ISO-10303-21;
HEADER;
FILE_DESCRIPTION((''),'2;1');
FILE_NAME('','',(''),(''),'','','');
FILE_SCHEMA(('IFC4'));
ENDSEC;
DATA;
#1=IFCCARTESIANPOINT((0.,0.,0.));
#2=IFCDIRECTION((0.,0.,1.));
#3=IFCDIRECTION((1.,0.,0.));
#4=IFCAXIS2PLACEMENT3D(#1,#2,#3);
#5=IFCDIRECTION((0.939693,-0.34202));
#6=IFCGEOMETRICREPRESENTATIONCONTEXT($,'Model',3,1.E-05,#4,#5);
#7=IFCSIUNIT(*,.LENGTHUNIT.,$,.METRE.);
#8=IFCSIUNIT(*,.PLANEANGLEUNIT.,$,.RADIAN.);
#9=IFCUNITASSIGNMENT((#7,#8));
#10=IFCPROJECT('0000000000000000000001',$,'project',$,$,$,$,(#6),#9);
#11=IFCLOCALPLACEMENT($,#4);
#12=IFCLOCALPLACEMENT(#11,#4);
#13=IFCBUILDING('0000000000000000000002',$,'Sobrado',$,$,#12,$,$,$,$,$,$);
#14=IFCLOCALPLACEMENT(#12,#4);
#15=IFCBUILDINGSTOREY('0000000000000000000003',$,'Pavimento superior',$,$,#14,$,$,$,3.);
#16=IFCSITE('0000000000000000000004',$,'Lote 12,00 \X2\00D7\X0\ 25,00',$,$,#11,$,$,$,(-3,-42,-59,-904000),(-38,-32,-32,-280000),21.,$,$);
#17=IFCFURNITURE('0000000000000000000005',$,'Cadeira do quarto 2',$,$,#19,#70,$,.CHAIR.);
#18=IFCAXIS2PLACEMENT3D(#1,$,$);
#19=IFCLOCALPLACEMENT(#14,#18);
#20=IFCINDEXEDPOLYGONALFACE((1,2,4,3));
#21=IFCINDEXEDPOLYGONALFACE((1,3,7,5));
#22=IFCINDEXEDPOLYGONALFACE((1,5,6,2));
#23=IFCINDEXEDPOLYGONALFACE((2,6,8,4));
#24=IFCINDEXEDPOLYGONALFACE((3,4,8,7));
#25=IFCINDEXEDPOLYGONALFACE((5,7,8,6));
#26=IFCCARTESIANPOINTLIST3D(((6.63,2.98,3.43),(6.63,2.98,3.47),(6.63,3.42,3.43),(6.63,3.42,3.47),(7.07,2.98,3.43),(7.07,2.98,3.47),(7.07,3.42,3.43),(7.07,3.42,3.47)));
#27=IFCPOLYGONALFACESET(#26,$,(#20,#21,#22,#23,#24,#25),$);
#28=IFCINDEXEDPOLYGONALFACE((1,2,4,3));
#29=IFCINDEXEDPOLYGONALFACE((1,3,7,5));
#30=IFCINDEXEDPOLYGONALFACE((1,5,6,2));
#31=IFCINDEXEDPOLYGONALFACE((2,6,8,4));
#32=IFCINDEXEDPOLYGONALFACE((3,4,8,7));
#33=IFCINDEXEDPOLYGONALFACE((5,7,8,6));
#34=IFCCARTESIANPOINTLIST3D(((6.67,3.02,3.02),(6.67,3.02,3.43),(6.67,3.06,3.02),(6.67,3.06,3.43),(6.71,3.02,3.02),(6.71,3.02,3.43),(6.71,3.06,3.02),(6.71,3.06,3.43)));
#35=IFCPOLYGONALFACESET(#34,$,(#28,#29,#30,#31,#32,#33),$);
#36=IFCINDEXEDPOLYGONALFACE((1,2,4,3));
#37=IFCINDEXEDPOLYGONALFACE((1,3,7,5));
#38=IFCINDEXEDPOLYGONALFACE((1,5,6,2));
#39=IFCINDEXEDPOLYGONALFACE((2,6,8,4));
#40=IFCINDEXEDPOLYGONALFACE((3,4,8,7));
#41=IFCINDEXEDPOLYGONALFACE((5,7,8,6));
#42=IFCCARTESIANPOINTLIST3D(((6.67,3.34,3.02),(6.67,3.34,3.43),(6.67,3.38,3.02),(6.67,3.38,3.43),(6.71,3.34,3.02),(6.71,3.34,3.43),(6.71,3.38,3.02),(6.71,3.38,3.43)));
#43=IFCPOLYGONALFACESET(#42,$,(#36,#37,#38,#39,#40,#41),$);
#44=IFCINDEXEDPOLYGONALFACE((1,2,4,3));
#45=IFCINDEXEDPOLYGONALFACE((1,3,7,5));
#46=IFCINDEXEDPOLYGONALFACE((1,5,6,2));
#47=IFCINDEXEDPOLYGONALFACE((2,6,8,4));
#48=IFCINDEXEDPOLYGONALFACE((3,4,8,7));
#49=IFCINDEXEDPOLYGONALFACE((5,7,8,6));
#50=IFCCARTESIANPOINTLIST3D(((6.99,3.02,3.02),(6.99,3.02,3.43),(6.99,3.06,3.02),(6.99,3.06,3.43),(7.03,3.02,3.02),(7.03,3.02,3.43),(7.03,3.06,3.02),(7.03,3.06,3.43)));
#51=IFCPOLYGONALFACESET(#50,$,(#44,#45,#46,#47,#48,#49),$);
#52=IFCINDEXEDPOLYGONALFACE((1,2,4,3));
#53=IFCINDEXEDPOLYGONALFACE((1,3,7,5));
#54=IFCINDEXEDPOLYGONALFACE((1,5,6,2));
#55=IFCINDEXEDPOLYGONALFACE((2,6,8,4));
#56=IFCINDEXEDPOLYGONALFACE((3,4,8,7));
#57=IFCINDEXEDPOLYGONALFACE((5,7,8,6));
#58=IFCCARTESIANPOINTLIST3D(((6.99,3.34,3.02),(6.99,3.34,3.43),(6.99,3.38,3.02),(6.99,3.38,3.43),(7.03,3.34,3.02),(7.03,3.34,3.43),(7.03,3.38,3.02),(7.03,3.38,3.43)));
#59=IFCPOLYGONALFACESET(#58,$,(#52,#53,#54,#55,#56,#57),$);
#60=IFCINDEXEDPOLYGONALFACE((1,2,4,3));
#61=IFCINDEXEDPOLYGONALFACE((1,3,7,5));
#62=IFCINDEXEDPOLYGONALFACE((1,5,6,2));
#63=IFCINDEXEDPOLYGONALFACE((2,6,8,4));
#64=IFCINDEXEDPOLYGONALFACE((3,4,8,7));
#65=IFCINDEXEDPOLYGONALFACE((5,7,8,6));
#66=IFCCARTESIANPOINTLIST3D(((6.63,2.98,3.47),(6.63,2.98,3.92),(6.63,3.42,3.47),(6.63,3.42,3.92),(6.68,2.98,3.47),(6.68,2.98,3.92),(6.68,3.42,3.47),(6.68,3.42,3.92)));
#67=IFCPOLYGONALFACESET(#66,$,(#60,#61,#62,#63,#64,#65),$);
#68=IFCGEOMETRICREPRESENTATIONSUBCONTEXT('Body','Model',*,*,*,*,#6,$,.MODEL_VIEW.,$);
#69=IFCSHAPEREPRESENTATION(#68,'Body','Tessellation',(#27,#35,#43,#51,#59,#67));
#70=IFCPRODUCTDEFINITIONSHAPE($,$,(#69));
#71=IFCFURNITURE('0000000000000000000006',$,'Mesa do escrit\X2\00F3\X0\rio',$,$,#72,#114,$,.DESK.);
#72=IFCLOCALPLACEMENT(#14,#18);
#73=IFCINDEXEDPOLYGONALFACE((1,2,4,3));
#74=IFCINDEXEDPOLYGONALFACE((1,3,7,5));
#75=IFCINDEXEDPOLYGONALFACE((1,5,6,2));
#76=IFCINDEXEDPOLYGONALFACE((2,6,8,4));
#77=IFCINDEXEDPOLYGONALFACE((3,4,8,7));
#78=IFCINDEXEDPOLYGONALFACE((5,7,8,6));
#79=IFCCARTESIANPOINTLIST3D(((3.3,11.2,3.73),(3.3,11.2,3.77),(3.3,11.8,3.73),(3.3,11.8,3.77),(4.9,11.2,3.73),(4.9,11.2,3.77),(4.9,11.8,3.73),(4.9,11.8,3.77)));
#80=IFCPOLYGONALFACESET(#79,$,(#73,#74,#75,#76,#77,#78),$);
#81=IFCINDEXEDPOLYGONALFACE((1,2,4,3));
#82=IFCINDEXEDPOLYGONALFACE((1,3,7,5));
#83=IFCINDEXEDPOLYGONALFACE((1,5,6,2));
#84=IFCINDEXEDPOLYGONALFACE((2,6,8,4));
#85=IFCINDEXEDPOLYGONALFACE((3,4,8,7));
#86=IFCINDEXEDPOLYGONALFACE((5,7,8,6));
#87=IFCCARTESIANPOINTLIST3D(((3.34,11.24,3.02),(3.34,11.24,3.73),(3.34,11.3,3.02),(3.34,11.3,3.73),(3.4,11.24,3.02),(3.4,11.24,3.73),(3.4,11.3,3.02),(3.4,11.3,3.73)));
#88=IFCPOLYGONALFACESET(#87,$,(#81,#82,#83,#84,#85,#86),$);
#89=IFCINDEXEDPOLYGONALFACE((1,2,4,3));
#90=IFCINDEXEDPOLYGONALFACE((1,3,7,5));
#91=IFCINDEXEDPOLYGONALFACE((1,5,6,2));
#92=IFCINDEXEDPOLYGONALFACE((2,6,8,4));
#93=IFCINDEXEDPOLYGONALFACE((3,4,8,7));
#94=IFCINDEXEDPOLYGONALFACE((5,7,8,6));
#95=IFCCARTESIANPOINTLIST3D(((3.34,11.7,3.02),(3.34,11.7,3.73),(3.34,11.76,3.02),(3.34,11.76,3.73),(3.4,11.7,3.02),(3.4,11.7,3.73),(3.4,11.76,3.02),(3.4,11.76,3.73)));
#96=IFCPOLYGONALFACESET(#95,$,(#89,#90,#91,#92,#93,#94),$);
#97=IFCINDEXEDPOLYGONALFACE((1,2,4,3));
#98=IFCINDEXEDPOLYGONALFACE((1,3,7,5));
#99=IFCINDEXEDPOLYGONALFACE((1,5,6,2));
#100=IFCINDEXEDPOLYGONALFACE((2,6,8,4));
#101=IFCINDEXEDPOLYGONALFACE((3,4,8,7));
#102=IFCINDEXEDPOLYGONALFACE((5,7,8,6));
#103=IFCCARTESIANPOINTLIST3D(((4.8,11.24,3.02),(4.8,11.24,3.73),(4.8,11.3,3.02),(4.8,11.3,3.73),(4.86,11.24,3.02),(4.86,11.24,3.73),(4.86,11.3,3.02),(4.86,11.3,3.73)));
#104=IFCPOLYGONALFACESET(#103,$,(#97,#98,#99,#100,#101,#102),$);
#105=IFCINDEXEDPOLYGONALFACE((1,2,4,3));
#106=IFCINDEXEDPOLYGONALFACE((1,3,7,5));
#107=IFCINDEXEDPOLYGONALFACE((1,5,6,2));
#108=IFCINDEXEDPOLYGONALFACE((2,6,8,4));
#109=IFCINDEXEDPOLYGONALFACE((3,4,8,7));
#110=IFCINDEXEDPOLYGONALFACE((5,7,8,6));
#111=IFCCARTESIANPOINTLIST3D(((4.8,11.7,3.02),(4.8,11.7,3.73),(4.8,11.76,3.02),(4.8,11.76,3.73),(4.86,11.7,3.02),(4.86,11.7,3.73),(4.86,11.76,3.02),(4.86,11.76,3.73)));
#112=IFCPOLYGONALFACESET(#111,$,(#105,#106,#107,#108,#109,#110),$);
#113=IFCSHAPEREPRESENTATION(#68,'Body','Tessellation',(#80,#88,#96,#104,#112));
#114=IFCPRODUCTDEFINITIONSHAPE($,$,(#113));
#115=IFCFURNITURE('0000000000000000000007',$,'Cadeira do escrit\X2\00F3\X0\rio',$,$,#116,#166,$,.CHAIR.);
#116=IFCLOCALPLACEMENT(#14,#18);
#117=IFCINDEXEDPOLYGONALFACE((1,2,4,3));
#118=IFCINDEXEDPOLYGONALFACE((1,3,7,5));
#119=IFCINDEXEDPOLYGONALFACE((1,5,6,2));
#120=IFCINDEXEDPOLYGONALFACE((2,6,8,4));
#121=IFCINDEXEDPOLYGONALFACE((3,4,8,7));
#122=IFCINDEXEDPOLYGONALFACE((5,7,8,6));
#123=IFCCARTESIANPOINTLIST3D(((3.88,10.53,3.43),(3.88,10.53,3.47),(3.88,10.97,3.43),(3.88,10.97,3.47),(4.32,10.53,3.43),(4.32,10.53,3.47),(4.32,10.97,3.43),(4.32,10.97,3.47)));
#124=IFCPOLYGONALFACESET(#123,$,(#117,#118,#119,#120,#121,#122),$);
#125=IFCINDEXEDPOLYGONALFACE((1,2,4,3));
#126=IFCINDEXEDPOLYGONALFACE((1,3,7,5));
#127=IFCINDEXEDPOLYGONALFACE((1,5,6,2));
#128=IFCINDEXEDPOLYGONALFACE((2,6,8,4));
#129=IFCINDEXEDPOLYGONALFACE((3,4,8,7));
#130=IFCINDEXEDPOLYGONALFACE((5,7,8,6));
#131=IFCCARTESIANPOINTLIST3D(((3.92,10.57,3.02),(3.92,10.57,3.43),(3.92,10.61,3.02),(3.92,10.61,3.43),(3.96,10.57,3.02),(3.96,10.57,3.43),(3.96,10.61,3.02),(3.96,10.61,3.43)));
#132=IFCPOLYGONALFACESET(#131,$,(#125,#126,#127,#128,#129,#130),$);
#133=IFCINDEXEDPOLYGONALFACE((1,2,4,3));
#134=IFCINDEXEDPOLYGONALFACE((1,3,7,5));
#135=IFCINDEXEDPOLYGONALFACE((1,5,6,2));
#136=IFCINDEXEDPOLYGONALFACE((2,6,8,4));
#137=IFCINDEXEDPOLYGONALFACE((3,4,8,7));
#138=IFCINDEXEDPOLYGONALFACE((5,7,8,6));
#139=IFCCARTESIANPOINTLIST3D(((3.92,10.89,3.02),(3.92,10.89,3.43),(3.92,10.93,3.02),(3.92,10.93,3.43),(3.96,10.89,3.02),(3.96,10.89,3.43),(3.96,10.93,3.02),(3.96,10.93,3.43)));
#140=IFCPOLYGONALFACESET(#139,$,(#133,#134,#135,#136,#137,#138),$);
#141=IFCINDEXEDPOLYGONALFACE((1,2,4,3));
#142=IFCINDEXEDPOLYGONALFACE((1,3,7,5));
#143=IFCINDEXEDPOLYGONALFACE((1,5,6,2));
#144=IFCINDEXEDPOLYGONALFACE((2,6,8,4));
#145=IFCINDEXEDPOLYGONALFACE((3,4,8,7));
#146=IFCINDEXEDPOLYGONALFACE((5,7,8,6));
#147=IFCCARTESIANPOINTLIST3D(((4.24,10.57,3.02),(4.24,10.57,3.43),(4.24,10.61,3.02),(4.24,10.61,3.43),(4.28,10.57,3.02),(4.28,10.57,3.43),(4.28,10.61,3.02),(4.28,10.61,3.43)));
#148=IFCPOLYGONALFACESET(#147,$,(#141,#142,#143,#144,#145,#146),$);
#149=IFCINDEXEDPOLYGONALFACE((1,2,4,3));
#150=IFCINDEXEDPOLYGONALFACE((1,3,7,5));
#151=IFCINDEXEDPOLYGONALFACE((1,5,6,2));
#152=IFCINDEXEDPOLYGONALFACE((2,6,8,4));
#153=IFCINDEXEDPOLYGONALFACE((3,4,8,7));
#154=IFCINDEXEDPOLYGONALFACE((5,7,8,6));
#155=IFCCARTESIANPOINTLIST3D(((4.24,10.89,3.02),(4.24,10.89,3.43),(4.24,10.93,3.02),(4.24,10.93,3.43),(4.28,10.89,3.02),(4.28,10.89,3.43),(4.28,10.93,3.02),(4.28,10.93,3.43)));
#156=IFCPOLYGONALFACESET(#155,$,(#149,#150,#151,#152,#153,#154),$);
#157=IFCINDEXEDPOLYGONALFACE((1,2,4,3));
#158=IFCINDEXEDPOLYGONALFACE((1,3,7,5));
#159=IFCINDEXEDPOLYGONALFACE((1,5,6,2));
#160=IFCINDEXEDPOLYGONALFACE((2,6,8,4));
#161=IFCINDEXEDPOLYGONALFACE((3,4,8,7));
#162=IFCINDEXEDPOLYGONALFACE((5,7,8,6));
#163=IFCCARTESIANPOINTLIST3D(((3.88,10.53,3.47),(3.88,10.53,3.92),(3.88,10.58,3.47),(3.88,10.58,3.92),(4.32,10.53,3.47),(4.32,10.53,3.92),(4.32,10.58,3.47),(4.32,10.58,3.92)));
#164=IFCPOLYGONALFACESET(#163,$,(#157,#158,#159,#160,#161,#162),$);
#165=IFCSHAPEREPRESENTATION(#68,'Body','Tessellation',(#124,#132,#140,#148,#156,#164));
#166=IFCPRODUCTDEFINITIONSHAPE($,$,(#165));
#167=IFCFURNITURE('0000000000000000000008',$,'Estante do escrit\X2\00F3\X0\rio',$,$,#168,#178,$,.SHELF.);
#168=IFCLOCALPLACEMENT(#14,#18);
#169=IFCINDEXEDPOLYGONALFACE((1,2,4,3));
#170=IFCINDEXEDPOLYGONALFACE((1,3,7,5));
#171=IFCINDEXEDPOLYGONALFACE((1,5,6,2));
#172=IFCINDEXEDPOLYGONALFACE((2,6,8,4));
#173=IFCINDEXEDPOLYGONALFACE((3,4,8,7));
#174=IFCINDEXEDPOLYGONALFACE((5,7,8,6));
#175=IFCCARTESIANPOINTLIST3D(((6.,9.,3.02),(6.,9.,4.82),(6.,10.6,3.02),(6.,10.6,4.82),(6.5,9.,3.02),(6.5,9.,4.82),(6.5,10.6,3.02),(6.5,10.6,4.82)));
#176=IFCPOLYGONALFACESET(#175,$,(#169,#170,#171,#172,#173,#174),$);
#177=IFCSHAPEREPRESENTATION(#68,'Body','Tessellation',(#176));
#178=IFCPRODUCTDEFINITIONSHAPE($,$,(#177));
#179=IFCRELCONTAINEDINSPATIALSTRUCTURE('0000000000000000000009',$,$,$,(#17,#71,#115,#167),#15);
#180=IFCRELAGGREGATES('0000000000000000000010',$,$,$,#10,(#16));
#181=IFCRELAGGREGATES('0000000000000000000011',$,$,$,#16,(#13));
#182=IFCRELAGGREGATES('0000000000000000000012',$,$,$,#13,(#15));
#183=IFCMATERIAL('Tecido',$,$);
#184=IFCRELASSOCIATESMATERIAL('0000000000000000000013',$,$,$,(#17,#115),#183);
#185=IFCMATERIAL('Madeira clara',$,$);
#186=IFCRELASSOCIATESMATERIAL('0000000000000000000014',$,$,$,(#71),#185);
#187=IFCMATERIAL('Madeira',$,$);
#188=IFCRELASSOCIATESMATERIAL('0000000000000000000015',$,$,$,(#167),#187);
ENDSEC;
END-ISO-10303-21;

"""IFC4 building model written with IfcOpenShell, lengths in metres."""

from ifc_helpers import new_model, si_unit, direction, frame, origin_with_axes, place, context, subcontext, project, spatial, line, indexed_curve, outline, extrude, material, element, save


model = new_model("IFC4")

# Units and contexts
model_context = context("Model", 3, precision=1e-05, world=origin_with_axes(), true_north=direction((0.939693, -0.34202)))
body_context = subcontext(model_context, "Body", "Model", "MODEL_VIEW")
ifc_project = project(units=[si_unit("LENGTHUNIT", "METRE"), si_unit("PLANEANGLEUNIT", "RADIAN")], contexts=[model_context])

# Site, building, storey
site_placement = place(None, origin_with_axes())
site = spatial("IfcSite", under=ifc_project, at=site_placement, Name="Lote 12,00 × 25,00", RefLatitude=(-3, -42, -59, -904000), RefLongitude=(-38, -32, -32, -280000), RefElevation=21.0)
building_placement = place(site_placement, origin_with_axes())
building = spatial("IfcBuilding", under=site, at=building_placement, Name="Sobrado")
storey_placement = place(building_placement, origin_with_axes())
storey = spatial("IfcBuildingStorey", under=building, at=storey_placement, Name="Pavimento superior", Elevation=3.0)

# Furniture
ifc_material_1 = material(Name="Tecido")
ifc_material_2 = material(Name="Madeira")
ifc_material_3 = material(Name="Madeira clara")
furniture_1_placement = place(storey_placement, origin_with_axes())
element("IfcFurniture", 1, at=furniture_1_placement, inside=storey, material=ifc_material_1, Name="Cadeira do quarto 2", PredefinedType="CHAIR", context=body_context, shape_type="SweptSolid", body=[
    extrude(outline(indexed_curve([(6.63, 2.98), (7.07, 2.98), (7.07, 3.42), (6.63, 3.42)], segments=[line(1, 2, 3, 4, 1)])), frame((0.0, 0.0, 3.43), z_axis=(0.0, 0.0, 1.0), x_axis=(1.0, 0.0, 0.0)), (0.0, 0.0, 1.0), 0.04),
    extrude(outline(indexed_curve([(6.67, 3.02), (6.71, 3.02), (6.71, 3.06), (6.67, 3.06)], segments=[line(1, 2, 3, 4, 1)])), frame((0.0, 0.0, 3.02), z_axis=(0.0, 0.0, 1.0), x_axis=(1.0, 0.0, 0.0)), (0.0, 0.0, 1.0), 0.41),
    extrude(outline(indexed_curve([(6.67, 3.34), (6.71, 3.34), (6.71, 3.38), (6.67, 3.38)], segments=[line(1, 2, 3, 4, 1)])), frame((0.0, 0.0, 3.02), z_axis=(0.0, 0.0, 1.0), x_axis=(1.0, 0.0, 0.0)), (0.0, 0.0, 1.0), 0.41),
    extrude(outline(indexed_curve([(6.99, 3.02), (7.03, 3.02), (7.03, 3.06), (6.99, 3.06)], segments=[line(1, 2, 3, 4, 1)])), frame((0.0, 0.0, 3.02), z_axis=(0.0, 0.0, 1.0), x_axis=(1.0, 0.0, 0.0)), (0.0, 0.0, 1.0), 0.41),
    extrude(outline(indexed_curve([(6.99, 3.34), (7.03, 3.34), (7.03, 3.38), (6.99, 3.38)], segments=[line(1, 2, 3, 4, 1)])), frame((0.0, 0.0, 3.02), z_axis=(0.0, 0.0, 1.0), x_axis=(1.0, 0.0, 0.0)), (0.0, 0.0, 1.0), 0.41),
    extrude(outline(indexed_curve([(6.63, 2.98), (6.68, 2.98), (6.68, 3.42), (6.63, 3.42)], segments=[line(1, 2, 3, 4, 1)])), frame((0.0, 0.0, 3.47), z_axis=(0.0, 0.0, 1.0), x_axis=(1.0, 0.0, 0.0)), (0.0, 0.0, 1.0), 0.45),
])
furniture_2_placement = place(storey_placement, origin_with_axes())
element("IfcFurniture", 2, at=furniture_2_placement, inside=storey, material=ifc_material_3, Name="Mesa do escritório", PredefinedType="DESK", context=body_context, shape_type="SweptSolid", body=[
    extrude(outline(indexed_curve([(3.3, 11.2), (4.9, 11.2), (4.9, 11.8), (3.3, 11.8)], segments=[line(1, 2, 3, 4, 1)])), frame((0.0, 0.0, 3.73), z_axis=(0.0, 0.0, 1.0), x_axis=(1.0, 0.0, 0.0)), (0.0, 0.0, 1.0), 0.04),
    extrude(outline(indexed_curve([(3.34, 11.24), (3.4, 11.24), (3.4, 11.3), (3.34, 11.3)], segments=[line(1, 2, 3, 4, 1)])), frame((0.0, 0.0, 3.02), z_axis=(0.0, 0.0, 1.0), x_axis=(1.0, 0.0, 0.0)), (0.0, 0.0, 1.0), 0.71),
    extrude(outline(indexed_curve([(3.34, 11.7), (3.4, 11.7), (3.4, 11.76), (3.34, 11.76)], segments=[line(1, 2, 3, 4, 1)])), frame((0.0, 0.0, 3.02), z_axis=(0.0, 0.0, 1.0), x_axis=(1.0, 0.0, 0.0)), (0.0, 0.0, 1.0), 0.71),
    extrude(outline(indexed_curve([(4.8, 11.24), (4.86, 11.24), (4.86, 11.3), (4.8, 11.3)], segments=[line(1, 2, 3, 4, 1)])), frame((0.0, 0.0, 3.02), z_axis=(0.0, 0.0, 1.0), x_axis=(1.0, 0.0, 0.0)), (0.0, 0.0, 1.0), 0.71),
    extrude(outline(indexed_curve([(4.8, 11.7), (4.86, 11.7), (4.86, 11.76), (4.8, 11.76)], segments=[line(1, 2, 3, 4, 1)])), frame((0.0, 0.0, 3.02), z_axis=(0.0, 0.0, 1.0), x_axis=(1.0, 0.0, 0.0)), (0.0, 0.0, 1.0), 0.71),
])
furniture_3_placement = place(storey_placement, origin_with_axes())
element("IfcFurniture", 3, at=furniture_3_placement, inside=storey, material=ifc_material_1, Name="Cadeira do escritório", PredefinedType="CHAIR", context=body_context, shape_type="SweptSolid", body=[
    extrude(outline(indexed_curve([(3.88, 10.53), (4.32, 10.53), (4.32, 10.97), (3.88, 10.97)], segments=[line(1, 2, 3, 4, 1)])), frame((0.0, 0.0, 3.43), z_axis=(0.0, 0.0, 1.0), x_axis=(1.0, 0.0, 0.0)), (0.0, 0.0, 1.0), 0.04),
    extrude(outline(indexed_curve([(3.92, 10.57), (3.96, 10.57), (3.96, 10.61), (3.92, 10.61)], segments=[line(1, 2, 3, 4, 1)])), frame((0.0, 0.0, 3.02), z_axis=(0.0, 0.0, 1.0), x_axis=(1.0, 0.0, 0.0)), (0.0, 0.0, 1.0), 0.41),
    extrude(outline(indexed_curve([(3.92, 10.89), (3.96, 10.89), (3.96, 10.93), (3.92, 10.93)], segments=[line(1, 2, 3, 4, 1)])), frame((0.0, 0.0, 3.02), z_axis=(0.0, 0.0, 1.0), x_axis=(1.0, 0.0, 0.0)), (0.0, 0.0, 1.0), 0.41),
    extrude(outline(indexed_curve([(4.24, 10.57), (4.28, 10.57), (4.28, 10.61), (4.24, 10.61)], segments=[line(1, 2, 3, 4, 1)])), frame((0.0, 0.0, 3.02), z_axis=(0.0, 0.0, 1.0), x_axis=(1.0, 0.0, 0.0)), (0.0, 0.0, 1.0), 0.41),
    extrude(outline(indexed_curve([(4.24, 10.89), (4.28, 10.89), (4.28, 10.93), (4.24, 10.93)], segments=[line(1, 2, 3, 4, 1)])), frame((0.0, 0.0, 3.02), z_axis=(0.0, 0.0, 1.0), x_axis=(1.0, 0.0, 0.0)), (0.0, 0.0, 1.0), 0.41),
    extrude(outline(indexed_curve([(3.88, 10.53), (4.32, 10.53), (4.32, 10.58), (3.88, 10.58)], segments=[line(1, 2, 3, 4, 1)])), frame((0.0, 0.0, 3.47), z_axis=(0.0, 0.0, 1.0), x_axis=(1.0, 0.0, 0.0)), (0.0, 0.0, 1.0), 0.45),
])
furniture_4_placement = place(storey_placement, origin_with_axes())
element("IfcFurniture", 4, at=furniture_4_placement, inside=storey, material=ifc_material_2, Name="Estante do escritório", PredefinedType="SHELF", context=body_context, shape_type="SweptSolid", body=[
    extrude(outline(indexed_curve([(6.0, 9.0), (6.5, 9.0), (6.5, 10.6), (6.0, 10.6)], segments=[line(1, 2, 3, 4, 1)])), frame((0.0, 0.0, 3.02), z_axis=(0.0, 0.0, 1.0), x_axis=(1.0, 0.0, 0.0)), (0.0, 0.0, 1.0), 1.8),
])

save(model, "model.ifc")
